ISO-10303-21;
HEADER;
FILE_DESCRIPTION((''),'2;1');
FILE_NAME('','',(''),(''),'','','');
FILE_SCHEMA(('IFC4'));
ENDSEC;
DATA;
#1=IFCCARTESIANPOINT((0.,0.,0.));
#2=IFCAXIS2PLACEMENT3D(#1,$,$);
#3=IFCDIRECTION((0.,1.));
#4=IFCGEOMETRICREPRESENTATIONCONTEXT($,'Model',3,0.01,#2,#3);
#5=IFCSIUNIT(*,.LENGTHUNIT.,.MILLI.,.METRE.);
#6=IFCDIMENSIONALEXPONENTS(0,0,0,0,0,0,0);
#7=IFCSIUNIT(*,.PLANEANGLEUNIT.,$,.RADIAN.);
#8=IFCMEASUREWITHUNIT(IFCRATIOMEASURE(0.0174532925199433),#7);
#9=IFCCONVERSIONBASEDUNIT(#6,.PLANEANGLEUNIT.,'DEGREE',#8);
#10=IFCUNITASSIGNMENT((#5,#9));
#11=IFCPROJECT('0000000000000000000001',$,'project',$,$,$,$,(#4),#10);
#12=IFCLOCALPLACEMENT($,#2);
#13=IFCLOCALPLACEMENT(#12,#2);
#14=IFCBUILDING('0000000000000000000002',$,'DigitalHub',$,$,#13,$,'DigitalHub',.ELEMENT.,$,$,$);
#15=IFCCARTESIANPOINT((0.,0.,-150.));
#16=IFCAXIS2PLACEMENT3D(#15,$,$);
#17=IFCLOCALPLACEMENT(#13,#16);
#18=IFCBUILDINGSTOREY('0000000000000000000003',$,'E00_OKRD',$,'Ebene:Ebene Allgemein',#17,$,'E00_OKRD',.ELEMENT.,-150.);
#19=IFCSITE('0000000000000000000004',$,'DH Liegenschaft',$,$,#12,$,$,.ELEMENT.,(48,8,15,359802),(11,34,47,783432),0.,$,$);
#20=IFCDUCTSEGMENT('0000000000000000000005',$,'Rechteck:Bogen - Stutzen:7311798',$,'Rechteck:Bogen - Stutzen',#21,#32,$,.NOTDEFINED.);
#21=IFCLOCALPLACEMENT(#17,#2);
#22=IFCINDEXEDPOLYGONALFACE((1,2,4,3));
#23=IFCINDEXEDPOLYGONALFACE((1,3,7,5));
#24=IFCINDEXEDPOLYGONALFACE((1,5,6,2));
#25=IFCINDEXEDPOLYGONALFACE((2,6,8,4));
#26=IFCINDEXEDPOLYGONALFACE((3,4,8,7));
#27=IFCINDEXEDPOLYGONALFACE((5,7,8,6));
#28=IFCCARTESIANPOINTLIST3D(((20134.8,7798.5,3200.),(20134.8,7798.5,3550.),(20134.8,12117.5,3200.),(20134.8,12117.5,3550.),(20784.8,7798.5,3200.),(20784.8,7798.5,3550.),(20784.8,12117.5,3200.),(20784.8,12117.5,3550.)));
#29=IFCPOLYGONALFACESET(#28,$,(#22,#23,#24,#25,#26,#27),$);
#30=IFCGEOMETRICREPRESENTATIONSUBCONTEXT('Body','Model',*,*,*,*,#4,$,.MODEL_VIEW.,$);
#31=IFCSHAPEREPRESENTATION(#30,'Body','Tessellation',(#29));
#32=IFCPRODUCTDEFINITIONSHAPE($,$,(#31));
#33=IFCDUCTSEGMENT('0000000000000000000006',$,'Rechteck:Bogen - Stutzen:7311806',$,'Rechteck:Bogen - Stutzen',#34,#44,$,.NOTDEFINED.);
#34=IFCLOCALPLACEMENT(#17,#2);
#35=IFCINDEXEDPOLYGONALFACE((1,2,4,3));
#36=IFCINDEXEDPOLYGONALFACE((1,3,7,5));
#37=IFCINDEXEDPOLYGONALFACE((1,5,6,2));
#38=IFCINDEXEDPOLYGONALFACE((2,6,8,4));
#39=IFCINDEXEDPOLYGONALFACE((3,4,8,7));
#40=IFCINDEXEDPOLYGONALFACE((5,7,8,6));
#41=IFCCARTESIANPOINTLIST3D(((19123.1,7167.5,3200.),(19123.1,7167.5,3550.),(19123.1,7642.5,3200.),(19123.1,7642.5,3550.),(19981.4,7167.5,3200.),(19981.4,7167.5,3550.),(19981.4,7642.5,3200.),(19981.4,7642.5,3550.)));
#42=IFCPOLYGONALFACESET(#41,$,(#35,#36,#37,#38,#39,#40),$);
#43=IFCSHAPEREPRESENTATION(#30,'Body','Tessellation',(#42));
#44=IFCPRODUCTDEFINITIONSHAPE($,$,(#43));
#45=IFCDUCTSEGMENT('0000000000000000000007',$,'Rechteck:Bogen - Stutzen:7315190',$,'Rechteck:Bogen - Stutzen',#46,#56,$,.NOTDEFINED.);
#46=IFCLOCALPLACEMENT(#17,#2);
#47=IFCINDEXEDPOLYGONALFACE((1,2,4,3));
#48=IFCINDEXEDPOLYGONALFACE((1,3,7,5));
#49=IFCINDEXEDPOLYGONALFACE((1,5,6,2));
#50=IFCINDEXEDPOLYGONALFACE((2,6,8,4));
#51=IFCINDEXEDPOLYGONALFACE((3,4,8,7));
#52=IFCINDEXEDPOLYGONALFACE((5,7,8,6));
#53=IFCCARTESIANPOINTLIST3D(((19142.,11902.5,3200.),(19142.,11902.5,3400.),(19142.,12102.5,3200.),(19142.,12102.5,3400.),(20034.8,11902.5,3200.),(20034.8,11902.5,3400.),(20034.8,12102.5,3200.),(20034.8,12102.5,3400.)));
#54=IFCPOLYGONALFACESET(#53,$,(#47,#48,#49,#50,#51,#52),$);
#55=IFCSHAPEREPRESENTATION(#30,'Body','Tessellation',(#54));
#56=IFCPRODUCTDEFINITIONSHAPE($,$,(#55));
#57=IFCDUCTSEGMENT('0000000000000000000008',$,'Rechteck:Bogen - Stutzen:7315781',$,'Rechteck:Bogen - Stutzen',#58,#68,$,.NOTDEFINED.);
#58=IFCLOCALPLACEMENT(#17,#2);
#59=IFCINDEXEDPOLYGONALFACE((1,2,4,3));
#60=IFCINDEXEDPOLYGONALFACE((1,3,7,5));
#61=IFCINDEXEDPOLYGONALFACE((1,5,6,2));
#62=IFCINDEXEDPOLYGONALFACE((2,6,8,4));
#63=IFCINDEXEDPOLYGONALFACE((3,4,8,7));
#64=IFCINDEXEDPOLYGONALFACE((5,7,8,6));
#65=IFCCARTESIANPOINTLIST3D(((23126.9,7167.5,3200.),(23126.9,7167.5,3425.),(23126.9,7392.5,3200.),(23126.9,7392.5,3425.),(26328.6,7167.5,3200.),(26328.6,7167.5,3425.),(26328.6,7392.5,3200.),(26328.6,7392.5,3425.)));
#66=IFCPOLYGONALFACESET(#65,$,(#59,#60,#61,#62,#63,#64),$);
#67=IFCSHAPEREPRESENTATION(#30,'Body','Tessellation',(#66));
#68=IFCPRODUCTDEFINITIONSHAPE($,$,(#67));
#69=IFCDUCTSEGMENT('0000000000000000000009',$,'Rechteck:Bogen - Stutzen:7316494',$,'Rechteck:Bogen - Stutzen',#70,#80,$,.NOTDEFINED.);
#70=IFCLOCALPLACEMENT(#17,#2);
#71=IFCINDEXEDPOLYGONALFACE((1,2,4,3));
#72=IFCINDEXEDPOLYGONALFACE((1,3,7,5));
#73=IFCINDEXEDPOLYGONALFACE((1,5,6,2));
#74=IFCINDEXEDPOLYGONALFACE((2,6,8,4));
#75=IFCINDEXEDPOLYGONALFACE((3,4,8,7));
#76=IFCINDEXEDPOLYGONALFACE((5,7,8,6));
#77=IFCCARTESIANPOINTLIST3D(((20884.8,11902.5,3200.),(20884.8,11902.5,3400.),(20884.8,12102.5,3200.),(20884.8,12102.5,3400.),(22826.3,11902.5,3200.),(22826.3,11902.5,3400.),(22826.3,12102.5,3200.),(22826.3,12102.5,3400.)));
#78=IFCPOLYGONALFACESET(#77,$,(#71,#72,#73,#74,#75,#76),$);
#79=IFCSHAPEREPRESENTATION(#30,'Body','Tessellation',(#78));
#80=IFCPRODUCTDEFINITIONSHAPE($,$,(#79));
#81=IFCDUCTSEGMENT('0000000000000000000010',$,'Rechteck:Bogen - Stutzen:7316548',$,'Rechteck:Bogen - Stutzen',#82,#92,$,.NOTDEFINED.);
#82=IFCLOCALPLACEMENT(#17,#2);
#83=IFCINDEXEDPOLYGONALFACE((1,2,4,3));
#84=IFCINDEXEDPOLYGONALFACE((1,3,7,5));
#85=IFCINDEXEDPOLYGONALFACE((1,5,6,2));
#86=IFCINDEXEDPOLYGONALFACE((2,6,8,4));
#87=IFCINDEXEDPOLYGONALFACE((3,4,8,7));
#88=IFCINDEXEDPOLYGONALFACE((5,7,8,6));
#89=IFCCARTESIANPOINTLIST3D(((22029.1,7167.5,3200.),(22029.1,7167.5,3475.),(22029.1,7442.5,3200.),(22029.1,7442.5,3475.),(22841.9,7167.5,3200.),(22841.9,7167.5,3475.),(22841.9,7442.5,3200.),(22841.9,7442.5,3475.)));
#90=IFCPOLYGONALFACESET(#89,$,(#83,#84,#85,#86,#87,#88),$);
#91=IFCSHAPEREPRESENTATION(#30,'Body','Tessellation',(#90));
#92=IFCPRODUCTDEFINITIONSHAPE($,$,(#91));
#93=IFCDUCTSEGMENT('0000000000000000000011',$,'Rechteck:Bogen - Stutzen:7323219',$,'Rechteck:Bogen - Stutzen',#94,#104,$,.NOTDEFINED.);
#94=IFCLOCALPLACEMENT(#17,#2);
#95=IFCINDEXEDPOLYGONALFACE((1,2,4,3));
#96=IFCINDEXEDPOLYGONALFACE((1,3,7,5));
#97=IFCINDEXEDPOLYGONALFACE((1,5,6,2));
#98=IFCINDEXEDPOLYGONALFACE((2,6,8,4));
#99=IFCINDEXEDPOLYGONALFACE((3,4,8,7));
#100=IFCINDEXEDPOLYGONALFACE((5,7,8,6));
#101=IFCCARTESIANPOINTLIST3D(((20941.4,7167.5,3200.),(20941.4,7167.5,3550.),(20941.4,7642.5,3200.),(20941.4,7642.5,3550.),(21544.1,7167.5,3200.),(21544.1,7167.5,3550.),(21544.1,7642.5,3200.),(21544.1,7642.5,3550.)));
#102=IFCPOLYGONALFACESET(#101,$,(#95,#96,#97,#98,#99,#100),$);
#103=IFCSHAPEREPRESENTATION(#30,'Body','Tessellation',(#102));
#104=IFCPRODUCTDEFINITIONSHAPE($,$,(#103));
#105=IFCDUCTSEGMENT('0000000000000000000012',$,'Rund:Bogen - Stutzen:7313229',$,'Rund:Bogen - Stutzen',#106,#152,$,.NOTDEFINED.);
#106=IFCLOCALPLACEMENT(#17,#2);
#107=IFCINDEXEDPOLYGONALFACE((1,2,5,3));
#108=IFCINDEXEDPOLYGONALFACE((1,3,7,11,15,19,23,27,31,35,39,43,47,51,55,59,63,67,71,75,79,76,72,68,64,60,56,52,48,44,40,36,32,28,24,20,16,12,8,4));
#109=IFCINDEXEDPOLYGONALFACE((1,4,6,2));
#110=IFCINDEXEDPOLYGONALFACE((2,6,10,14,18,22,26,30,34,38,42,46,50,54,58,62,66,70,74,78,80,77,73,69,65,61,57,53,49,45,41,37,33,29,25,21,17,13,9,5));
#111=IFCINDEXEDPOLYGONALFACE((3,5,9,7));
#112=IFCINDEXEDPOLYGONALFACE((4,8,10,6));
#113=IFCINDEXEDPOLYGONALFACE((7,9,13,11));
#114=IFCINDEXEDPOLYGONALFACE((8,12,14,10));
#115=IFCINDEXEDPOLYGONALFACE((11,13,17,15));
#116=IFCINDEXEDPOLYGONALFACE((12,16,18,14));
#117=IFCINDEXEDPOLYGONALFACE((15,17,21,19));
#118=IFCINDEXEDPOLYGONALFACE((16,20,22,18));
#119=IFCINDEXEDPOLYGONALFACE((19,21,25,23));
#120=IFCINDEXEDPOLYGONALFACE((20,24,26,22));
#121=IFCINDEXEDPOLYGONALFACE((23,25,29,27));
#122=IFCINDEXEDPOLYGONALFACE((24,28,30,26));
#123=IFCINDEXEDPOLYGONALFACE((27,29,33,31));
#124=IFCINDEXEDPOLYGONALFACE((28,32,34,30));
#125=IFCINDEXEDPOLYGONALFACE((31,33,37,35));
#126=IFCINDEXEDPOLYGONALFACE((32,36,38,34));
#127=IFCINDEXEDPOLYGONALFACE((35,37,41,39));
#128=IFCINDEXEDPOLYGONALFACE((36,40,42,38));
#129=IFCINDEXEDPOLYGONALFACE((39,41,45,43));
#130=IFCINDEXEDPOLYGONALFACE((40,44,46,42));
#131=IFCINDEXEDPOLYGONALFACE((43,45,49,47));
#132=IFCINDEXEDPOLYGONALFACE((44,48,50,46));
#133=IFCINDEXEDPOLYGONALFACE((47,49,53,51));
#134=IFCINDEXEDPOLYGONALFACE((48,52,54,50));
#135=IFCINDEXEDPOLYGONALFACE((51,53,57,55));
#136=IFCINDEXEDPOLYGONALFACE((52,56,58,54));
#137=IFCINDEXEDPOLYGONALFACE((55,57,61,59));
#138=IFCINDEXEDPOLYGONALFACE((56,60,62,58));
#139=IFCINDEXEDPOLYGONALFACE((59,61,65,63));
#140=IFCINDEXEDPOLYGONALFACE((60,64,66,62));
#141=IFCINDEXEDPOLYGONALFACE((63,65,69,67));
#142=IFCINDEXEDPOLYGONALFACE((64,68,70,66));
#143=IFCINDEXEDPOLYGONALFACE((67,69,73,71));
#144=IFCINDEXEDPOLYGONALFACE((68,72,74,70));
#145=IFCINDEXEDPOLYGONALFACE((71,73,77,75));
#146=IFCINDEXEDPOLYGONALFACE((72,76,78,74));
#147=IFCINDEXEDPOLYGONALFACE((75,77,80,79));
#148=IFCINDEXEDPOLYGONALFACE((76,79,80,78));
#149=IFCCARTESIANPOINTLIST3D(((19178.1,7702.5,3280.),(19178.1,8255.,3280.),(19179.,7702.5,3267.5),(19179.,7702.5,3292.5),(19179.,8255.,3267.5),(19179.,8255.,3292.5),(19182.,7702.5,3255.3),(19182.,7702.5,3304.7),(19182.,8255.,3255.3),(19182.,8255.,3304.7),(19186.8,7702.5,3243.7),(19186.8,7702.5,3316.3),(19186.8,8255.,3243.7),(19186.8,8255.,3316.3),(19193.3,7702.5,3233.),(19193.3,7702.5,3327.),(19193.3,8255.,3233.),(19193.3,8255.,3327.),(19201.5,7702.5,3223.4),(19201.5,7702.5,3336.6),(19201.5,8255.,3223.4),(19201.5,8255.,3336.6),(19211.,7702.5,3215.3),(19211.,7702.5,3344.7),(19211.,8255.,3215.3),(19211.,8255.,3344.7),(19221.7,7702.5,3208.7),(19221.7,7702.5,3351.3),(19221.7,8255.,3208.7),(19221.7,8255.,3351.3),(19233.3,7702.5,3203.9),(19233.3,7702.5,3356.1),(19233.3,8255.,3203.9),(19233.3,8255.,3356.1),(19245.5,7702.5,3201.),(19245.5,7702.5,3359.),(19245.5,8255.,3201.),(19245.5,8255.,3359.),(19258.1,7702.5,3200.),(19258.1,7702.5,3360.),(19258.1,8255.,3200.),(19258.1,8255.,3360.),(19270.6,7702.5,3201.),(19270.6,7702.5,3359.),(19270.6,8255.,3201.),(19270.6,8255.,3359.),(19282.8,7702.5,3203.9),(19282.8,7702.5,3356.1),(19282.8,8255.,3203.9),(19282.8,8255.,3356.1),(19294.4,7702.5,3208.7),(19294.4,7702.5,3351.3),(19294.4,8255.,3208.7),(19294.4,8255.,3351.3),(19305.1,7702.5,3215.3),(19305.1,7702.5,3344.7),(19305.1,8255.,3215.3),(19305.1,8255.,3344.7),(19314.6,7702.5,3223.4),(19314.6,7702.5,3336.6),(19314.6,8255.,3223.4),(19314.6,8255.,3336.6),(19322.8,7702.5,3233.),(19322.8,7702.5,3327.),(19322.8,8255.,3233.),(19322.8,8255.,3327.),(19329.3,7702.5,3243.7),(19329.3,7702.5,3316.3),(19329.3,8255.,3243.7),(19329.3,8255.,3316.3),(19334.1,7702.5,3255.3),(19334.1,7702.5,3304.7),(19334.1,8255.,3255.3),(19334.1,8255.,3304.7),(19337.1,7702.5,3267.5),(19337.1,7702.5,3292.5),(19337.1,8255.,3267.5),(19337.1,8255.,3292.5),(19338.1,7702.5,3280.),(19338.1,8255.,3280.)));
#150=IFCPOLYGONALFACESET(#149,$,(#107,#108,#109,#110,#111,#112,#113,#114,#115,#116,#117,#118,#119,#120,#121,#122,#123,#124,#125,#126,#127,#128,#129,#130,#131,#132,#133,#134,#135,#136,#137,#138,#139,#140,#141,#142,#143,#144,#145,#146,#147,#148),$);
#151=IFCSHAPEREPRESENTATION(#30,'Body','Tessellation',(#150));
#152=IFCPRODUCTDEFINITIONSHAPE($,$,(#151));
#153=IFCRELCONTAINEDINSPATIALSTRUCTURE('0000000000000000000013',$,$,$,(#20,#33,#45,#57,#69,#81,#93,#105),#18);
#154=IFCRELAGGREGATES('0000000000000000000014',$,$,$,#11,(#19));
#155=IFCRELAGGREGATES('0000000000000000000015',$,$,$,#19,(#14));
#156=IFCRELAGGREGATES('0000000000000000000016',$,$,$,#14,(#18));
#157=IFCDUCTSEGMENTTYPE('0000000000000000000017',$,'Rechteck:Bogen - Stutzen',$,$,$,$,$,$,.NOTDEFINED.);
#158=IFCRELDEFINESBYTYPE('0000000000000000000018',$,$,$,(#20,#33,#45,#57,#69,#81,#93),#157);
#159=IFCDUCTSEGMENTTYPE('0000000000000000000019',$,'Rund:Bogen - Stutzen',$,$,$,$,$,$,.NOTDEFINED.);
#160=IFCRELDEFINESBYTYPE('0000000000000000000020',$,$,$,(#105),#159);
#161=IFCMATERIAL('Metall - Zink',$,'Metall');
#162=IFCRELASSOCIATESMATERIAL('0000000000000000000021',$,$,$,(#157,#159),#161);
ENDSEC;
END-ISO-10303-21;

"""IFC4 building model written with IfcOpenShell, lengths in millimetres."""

from ifc_helpers import new_model, entity, si_unit, converted_unit, direction, frame, origin, place, context, subcontext, project, spatial, indexed_curve, outline, extrude, material, type_object, element, save


model = new_model("IFC4")

# Units and contexts
model_context = context("Model", 3, precision=0.01, world=origin(), true_north=direction((0.0, 1.0)))
body_context = subcontext(model_context, "Body", "Model", "MODEL_VIEW")
ifc_project = project(units=[si_unit("LENGTHUNIT", "METRE", prefix="MILLI"), converted_unit("PLANEANGLEUNIT", "DEGREE", entity("IfcRatioMeasure", 0.0174532925199433), si_unit("PLANEANGLEUNIT", "RADIAN"), dimensions=[0, 0, 0, 0, 0, 0, 0])], contexts=[model_context])

# Site, building, storey
site_placement = place(None, origin())
site = spatial("IfcSite", under=ifc_project, at=site_placement, Name="DH Liegenschaft", CompositionType="ELEMENT", RefLatitude=(48, 8, 15, 359802), RefLongitude=(11, 34, 47, 783432), RefElevation=0.0)
building_placement = place(site_placement, origin())
building = spatial("IfcBuilding", under=site, at=building_placement, Name="DigitalHub", LongName="DigitalHub", CompositionType="ELEMENT")
storey_placement = place(building_placement, frame((0.0, 0.0, -150.0)))
storey = spatial("IfcBuildingStorey", under=building, at=storey_placement, Name="E00_OKRD", ObjectType="Ebene:Ebene Allgemein", LongName="E00_OKRD", CompositionType="ELEMENT", Elevation=-150.0)

# Duct segments
ifc_material_1 = material(Name="Metall - Zink", Category="Metall")
duct_segment_type_1 = type_object("IfcDuctSegmentType", Name="Rechteck:Bogen - Stutzen", PredefinedType="NOTDEFINED", material=ifc_material_1)
duct_segment_1_placement = place(storey_placement, frame((20134.8, 7798.5, 3200.0)))
element("IfcDuctSegment", 1, at=duct_segment_1_placement, inside=storey, type_object=duct_segment_type_1, Name="Rechteck:Bogen - Stutzen:7311798", ObjectType="Rechteck:Bogen - Stutzen", PredefinedType="NOTDEFINED", context=body_context, shape_type="SweptSolid", body=[
    extrude(outline(indexed_curve([(-2159.5, -325.0), (2159.5, -325.0), (2159.5, 325.0), (-2159.5, 325.0), (-2159.5, -325.0)], self_intersect=False)), frame((325.0, 2159.5, 0.0), z_axis=(0.0, 0.0, 1.0), x_axis=(0.0, -1.0, 0.0)), (0.0, 0.0, 1.0), 350.0),
])
duct_segment_2_placement = place(storey_placement, frame((19123.1, 7167.5, 3200.0)))
element("IfcDuctSegment", 2, at=duct_segment_2_placement, inside=storey, type_object=duct_segment_type_1, Name="Rechteck:Bogen - Stutzen:7311806", ObjectType="Rechteck:Bogen - Stutzen", PredefinedType="NOTDEFINED", context=body_context, shape_type="SweptSolid", body=[
    extrude(outline(indexed_curve([(-429.2, -237.5), (429.2, -237.5), (429.2, 237.5), (-429.2, 237.5), (-429.2, -237.5)], self_intersect=False)), frame((429.2, 237.5, 0.0)), (0.0, 0.0, 1.0), 350.0),
])
duct_segment_3_placement = place(storey_placement, frame((19142.0, 11902.5, 3200.0)))
element("IfcDuctSegment", 3, at=duct_segment_3_placement, inside=storey, type_object=duct_segment_type_1, Name="Rechteck:Bogen - Stutzen:7315190", ObjectType="Rechteck:Bogen - Stutzen", PredefinedType="NOTDEFINED", context=body_context, shape_type="SweptSolid", body=[
    extrude(outline(indexed_curve([(-446.4, -100.0), (446.4, -100.0), (446.4, 100.0), (-446.4, 100.0), (-446.4, -100.0)], self_intersect=False)), frame((446.4, 100.0, 0.0)), (0.0, 0.0, 1.0), 200.0),
])
duct_segment_4_placement = place(storey_placement, frame((23126.9, 7167.5, 3200.0)))
element("IfcDuctSegment", 4, at=duct_segment_4_placement, inside=storey, type_object=duct_segment_type_1, Name="Rechteck:Bogen - Stutzen:7315781", ObjectType="Rechteck:Bogen - Stutzen", PredefinedType="NOTDEFINED", context=body_context, shape_type="SweptSolid", body=[
    extrude(outline(indexed_curve([(-1600.8, -112.5), (1600.8, -112.5), (1600.8, 112.5), (-1600.8, 112.5), (-1600.8, -112.5)], self_intersect=False)), frame((1600.8, 112.5, 0.0)), (0.0, 0.0, 1.0), 225.0),
])
duct_segment_5_placement = place(storey_placement, frame((20884.8, 11902.5, 3200.0)))
element("IfcDuctSegment", 5, at=duct_segment_5_placement, inside=storey, type_object=duct_segment_type_1, Name="Rechteck:Bogen - Stutzen:7316494", ObjectType="Rechteck:Bogen - Stutzen", PredefinedType="NOTDEFINED", context=body_context, shape_type="SweptSolid", body=[
    extrude(outline(indexed_curve([(-970.7, -100.0), (970.7, -100.0), (970.7, 100.0), (-970.7, 100.0), (-970.7, -100.0)], self_intersect=False)), frame((970.7, 100.0, 0.0), z_axis=(0.0, 0.0, 1.0), x_axis=(-1.0, 0.0, 0.0)), (0.0, 0.0, 1.0), 200.0),
])
duct_segment_6_placement = place(storey_placement, frame((22029.1, 7167.5, 3200.0)))
element("IfcDuctSegment", 6, at=duct_segment_6_placement, inside=storey, type_object=duct_segment_type_1, Name="Rechteck:Bogen - Stutzen:7316548", ObjectType="Rechteck:Bogen - Stutzen", PredefinedType="NOTDEFINED", context=body_context, shape_type="SweptSolid", body=[
    extrude(outline(indexed_curve([(-406.4, -137.5), (406.4, -137.5), (406.4, 137.5), (-406.4, 137.5), (-406.4, -137.5)], self_intersect=False)), frame((406.4, 137.5, 0.0), z_axis=(0.0, 0.0, 1.0), x_axis=(-1.0, 0.0, 0.0)), (0.0, 0.0, 1.0), 275.0),
])
duct_segment_7_placement = place(storey_placement, frame((20941.4, 7167.5, 3200.0)))
element("IfcDuctSegment", 7, at=duct_segment_7_placement, inside=storey, type_object=duct_segment_type_1, Name="Rechteck:Bogen - Stutzen:7323219", ObjectType="Rechteck:Bogen - Stutzen", PredefinedType="NOTDEFINED", context=body_context, shape_type="SweptSolid", body=[
    extrude(outline(indexed_curve([(-301.3, -237.5), (301.3, -237.5), (301.3, 237.5), (-301.3, 237.5), (-301.3, -237.5)], self_intersect=False)), frame((301.3, 237.5, 0.0), z_axis=(0.0, 0.0, 1.0), x_axis=(-1.0, 0.0, 0.0)), (0.0, 0.0, 1.0), 350.0),
])
duct_segment_type_2 = type_object("IfcDuctSegmentType", Name="Rund:Bogen - Stutzen", PredefinedType="NOTDEFINED", material=ifc_material_1)
duct_segment_8_placement = place(storey_placement, frame((19176.5, 7702.5, 3198.4)))
element("IfcDuctSegment", 8, at=duct_segment_8_placement, inside=storey, type_object=duct_segment_type_2, Name="Rund:Bogen - Stutzen:7313229", ObjectType="Rund:Bogen - Stutzen", PredefinedType="NOTDEFINED", context=body_context, shape_type="SweptSolid", body=[
    extrude(outline(indexed_curve([(80.0, 0.0), (79.0, 12.5), (76.1, 24.7), (71.3, 36.3), (64.7, 47.0), (56.6, 56.6), (47.0, 64.7), (36.3, 71.3), (24.7, 76.1), (12.5, 79.0), (0.0, 80.0), (-12.5, 79.0), (-24.7, 76.1), (-36.3, 71.3), (-47.0, 64.7), (-56.6, 56.6), (-64.7, 47.0), (-71.3, 36.3), (-76.1, 24.7), (-79.0, 12.5), (-80.0, 0.0), (-79.0, -12.5), (-76.1, -24.7), (-71.3, -36.3), (-64.7, -47.0), (-56.6, -56.6), (-47.0, -64.7), (-36.3, -71.3), (-24.7, -76.1), (-12.5, -79.0), (0.0, -80.0), (12.5, -79.0), (24.7, -76.1), (36.3, -71.3), (47.0, -64.7), (56.6, -56.6), (64.7, -47.0), (71.3, -36.3), (76.1, -24.7), (79.0, -12.5), (80.0, 0.0)], self_intersect=False)), frame((81.6, 0.0, 81.6), z_axis=(0.0, 1.0, 0.0), x_axis=(1.0, 0.0, 0.0)), (0.0, 0.0, 1.0), 552.4),
])

save(model, "model.ifc")
